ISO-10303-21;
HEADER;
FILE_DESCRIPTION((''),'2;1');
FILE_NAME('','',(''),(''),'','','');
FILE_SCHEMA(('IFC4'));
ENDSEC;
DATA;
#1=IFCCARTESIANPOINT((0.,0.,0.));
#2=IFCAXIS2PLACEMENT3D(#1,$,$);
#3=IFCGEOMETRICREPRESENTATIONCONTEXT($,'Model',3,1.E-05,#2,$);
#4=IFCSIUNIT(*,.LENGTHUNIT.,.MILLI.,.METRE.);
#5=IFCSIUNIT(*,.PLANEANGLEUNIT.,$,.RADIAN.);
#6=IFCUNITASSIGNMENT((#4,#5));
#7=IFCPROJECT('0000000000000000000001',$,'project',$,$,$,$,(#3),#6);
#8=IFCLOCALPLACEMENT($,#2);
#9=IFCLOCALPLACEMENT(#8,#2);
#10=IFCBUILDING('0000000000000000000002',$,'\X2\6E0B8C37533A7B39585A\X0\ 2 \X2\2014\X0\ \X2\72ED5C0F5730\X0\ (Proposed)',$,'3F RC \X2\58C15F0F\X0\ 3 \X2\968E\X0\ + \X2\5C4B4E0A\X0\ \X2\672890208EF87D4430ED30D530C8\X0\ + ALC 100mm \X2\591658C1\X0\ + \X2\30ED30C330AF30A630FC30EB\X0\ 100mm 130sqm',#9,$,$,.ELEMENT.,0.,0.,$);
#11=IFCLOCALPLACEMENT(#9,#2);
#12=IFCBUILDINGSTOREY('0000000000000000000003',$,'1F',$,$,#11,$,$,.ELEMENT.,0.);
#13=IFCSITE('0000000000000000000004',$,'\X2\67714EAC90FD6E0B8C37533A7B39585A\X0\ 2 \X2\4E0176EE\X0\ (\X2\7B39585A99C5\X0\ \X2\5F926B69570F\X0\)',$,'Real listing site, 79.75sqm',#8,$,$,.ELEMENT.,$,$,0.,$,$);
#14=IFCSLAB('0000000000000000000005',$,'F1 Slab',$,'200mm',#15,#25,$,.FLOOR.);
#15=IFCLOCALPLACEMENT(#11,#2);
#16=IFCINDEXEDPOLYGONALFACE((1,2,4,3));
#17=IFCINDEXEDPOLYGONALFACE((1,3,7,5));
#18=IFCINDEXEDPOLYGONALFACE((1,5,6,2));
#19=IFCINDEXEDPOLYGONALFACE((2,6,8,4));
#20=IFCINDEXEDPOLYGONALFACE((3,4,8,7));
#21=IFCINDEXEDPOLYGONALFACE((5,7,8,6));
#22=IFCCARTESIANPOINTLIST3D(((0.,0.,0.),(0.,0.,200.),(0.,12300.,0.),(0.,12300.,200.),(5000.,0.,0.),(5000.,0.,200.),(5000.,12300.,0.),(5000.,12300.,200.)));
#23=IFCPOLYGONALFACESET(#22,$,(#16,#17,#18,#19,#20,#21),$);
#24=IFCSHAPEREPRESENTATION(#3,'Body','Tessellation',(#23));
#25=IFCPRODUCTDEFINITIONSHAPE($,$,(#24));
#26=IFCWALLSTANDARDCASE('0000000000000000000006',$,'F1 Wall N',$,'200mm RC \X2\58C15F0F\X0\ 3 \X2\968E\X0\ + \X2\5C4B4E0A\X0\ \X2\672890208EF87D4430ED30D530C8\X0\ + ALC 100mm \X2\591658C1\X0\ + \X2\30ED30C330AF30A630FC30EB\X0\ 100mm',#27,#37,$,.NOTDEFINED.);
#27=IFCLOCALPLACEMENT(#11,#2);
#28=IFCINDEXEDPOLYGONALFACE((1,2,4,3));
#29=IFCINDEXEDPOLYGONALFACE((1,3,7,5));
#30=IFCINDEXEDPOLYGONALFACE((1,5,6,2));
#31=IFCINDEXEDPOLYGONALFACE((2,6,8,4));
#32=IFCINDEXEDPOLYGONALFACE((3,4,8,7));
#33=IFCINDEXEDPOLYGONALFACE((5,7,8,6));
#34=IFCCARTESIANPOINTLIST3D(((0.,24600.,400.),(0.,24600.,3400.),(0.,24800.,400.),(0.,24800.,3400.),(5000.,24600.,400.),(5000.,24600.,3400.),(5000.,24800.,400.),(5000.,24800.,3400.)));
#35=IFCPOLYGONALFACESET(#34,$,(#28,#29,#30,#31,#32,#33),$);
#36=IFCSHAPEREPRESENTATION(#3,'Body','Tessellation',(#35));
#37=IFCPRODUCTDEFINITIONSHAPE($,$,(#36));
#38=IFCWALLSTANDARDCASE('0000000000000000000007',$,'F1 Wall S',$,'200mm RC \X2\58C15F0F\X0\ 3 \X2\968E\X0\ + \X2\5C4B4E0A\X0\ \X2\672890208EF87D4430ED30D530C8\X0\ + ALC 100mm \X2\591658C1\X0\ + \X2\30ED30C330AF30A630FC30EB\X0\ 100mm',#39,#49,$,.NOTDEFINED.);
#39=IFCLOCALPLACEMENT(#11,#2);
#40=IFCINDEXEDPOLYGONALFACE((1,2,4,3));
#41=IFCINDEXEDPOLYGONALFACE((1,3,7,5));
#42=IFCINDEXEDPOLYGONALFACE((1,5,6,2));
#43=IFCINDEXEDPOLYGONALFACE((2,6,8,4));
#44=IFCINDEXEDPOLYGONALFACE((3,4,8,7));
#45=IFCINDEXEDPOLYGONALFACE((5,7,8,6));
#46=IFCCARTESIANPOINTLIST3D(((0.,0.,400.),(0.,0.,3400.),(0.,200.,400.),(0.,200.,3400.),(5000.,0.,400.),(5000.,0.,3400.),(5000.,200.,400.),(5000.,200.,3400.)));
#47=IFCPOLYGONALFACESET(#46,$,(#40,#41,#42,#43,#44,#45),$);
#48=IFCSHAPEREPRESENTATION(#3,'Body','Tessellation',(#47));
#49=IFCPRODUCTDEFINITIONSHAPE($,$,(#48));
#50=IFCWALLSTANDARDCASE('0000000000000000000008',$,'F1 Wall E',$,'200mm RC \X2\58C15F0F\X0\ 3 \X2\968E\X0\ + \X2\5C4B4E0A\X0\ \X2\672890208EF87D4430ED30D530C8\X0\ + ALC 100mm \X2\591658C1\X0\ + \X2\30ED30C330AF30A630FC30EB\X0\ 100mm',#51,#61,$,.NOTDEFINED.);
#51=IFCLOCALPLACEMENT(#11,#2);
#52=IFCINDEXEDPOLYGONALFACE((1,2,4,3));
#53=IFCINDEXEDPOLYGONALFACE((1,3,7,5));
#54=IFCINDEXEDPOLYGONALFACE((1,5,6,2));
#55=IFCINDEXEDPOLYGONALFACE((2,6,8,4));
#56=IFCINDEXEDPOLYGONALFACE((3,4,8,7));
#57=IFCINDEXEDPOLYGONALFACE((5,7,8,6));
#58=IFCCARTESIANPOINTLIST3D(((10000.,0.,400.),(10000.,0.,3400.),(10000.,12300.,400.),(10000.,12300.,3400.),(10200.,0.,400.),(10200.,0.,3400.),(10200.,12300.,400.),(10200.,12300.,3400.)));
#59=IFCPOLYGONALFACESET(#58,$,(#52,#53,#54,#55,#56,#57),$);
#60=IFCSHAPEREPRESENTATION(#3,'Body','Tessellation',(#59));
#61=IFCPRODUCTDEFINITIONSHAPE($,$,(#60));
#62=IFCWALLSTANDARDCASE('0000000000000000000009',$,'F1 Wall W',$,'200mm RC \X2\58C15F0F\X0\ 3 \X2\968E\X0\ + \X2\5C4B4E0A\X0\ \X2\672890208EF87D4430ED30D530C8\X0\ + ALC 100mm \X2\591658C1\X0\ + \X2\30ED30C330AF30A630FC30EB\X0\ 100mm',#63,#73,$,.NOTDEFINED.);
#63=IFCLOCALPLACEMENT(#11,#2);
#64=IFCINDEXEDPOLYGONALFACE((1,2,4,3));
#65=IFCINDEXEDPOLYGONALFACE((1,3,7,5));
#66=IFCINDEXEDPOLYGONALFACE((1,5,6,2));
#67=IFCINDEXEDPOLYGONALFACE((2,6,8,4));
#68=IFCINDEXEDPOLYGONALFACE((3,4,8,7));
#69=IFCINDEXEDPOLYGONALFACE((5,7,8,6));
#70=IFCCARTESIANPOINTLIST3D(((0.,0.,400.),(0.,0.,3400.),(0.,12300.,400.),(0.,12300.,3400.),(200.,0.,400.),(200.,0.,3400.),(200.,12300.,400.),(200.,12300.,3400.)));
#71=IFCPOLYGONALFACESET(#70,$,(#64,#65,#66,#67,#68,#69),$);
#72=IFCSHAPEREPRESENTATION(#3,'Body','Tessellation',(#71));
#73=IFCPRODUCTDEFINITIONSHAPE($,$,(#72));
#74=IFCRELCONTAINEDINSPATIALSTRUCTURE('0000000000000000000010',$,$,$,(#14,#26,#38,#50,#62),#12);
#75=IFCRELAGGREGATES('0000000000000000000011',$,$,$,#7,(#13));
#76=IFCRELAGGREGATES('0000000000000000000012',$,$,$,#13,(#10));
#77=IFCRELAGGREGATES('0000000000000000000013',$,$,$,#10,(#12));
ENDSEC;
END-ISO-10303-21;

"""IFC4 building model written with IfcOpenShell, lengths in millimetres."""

from ifc_helpers import new_model, si_unit, frame, frame_2d, origin, place, context, project, spatial, rectangle, extrude, element, save


model = new_model("IFC4")

# Units and contexts
model_context = context("Model", 3, precision=1e-05, world=origin())
ifc_project = project(units=[si_unit("LENGTHUNIT", "METRE", prefix="MILLI"), si_unit("PLANEANGLEUNIT", "RADIAN")], contexts=[model_context])

# Site, building, storey
site_placement = place(None, origin())
site = spatial("IfcSite", under=ifc_project, at=site_placement, Name="東京都渋谷区笹塚 2 丁目 (笹塚駅 徒歩圏)", ObjectType="Real listing site, 79.75sqm", CompositionType="ELEMENT", RefElevation=0.0)
building_placement = place(site_placement, origin())
building = spatial("IfcBuilding", under=site, at=building_placement, Name="渋谷区笹塚 2 — 狭小地 (Proposed)", ObjectType="3F RC 壁式 3 階 + 屋上 木造軸組ロフト + ALC 100mm 外壁 + ロックウール 100mm 130sqm", CompositionType="ELEMENT", ElevationOfRefHeight=0.0, ElevationOfTerrain=0.0)
storey_placement = place(building_placement, origin())
storey = spatial("IfcBuildingStorey", under=building, at=storey_placement, Name="1F", CompositionType="ELEMENT", Elevation=0.0)

# Slab
slab_placement = place(storey_placement, origin())
element("IfcSlab", 1, at=slab_placement, inside=storey, Name="F1 Slab", ObjectType="200mm", PredefinedType="FLOOR", context=model_context, shape_type="SweptSolid", body=[
    extrude(rectangle(XDim=5000.0, YDim=12300.0, at=frame_2d((2500.0, 6150.0))), origin(), (0.0, 0.0, 1.0), 200.0),
])

# Walls
wall_1_placement = place(storey_placement, frame((0.0, 12300.0, 200.0)))
element("IfcWallStandardCase", 2, at=wall_1_placement, inside=storey, Name="F1 Wall N", ObjectType="200mm RC 壁式 3 階 + 屋上 木造軸組ロフト + ALC 100mm 外壁 + ロックウール 100mm", PredefinedType="NOTDEFINED", context=model_context, shape_type="SweptSolid", body=[
    extrude(rectangle(XDim=5000.0, YDim=200.0, at=frame_2d((2500.0, 100.0))), frame((0.0, 12300.0, 200.0)), (0.0, 0.0, 1.0), 3000.0),
])
wall_2_placement = place(storey_placement, frame((0.0, 0.0, 200.0)))
element("IfcWallStandardCase", 3, at=wall_2_placement, inside=storey, Name="F1 Wall S", ObjectType="200mm RC 壁式 3 階 + 屋上 木造軸組ロフト + ALC 100mm 外壁 + ロックウール 100mm", PredefinedType="NOTDEFINED", context=model_context, shape_type="SweptSolid", body=[
    extrude(rectangle(XDim=5000.0, YDim=200.0, at=frame_2d((2500.0, 100.0))), frame((0.0, 0.0, 200.0)), (0.0, 0.0, 1.0), 3000.0),
])
wall_3_placement = place(storey_placement, frame((5000.0, 0.0, 200.0)))
element("IfcWallStandardCase", 4, at=wall_3_placement, inside=storey, Name="F1 Wall E", ObjectType="200mm RC 壁式 3 階 + 屋上 木造軸組ロフト + ALC 100mm 外壁 + ロックウール 100mm", PredefinedType="NOTDEFINED", context=model_context, shape_type="SweptSolid", body=[
    extrude(rectangle(XDim=200.0, YDim=12300.0, at=frame_2d((100.0, 6150.0))), frame((5000.0, 0.0, 200.0)), (0.0, 0.0, 1.0), 3000.0),
])
wall_4_placement = place(storey_placement, frame((0.0, 0.0, 200.0)))
element("IfcWallStandardCase", 5, at=wall_4_placement, inside=storey, Name="F1 Wall W", ObjectType="200mm RC 壁式 3 階 + 屋上 木造軸組ロフト + ALC 100mm 外壁 + ロックウール 100mm", PredefinedType="NOTDEFINED", context=model_context, shape_type="SweptSolid", body=[
    extrude(rectangle(XDim=200.0, YDim=12300.0, at=frame_2d((100.0, 6150.0))), frame((0.0, 0.0, 200.0)), (0.0, 0.0, 1.0), 3000.0),
])

save(model, "model.ifc")
